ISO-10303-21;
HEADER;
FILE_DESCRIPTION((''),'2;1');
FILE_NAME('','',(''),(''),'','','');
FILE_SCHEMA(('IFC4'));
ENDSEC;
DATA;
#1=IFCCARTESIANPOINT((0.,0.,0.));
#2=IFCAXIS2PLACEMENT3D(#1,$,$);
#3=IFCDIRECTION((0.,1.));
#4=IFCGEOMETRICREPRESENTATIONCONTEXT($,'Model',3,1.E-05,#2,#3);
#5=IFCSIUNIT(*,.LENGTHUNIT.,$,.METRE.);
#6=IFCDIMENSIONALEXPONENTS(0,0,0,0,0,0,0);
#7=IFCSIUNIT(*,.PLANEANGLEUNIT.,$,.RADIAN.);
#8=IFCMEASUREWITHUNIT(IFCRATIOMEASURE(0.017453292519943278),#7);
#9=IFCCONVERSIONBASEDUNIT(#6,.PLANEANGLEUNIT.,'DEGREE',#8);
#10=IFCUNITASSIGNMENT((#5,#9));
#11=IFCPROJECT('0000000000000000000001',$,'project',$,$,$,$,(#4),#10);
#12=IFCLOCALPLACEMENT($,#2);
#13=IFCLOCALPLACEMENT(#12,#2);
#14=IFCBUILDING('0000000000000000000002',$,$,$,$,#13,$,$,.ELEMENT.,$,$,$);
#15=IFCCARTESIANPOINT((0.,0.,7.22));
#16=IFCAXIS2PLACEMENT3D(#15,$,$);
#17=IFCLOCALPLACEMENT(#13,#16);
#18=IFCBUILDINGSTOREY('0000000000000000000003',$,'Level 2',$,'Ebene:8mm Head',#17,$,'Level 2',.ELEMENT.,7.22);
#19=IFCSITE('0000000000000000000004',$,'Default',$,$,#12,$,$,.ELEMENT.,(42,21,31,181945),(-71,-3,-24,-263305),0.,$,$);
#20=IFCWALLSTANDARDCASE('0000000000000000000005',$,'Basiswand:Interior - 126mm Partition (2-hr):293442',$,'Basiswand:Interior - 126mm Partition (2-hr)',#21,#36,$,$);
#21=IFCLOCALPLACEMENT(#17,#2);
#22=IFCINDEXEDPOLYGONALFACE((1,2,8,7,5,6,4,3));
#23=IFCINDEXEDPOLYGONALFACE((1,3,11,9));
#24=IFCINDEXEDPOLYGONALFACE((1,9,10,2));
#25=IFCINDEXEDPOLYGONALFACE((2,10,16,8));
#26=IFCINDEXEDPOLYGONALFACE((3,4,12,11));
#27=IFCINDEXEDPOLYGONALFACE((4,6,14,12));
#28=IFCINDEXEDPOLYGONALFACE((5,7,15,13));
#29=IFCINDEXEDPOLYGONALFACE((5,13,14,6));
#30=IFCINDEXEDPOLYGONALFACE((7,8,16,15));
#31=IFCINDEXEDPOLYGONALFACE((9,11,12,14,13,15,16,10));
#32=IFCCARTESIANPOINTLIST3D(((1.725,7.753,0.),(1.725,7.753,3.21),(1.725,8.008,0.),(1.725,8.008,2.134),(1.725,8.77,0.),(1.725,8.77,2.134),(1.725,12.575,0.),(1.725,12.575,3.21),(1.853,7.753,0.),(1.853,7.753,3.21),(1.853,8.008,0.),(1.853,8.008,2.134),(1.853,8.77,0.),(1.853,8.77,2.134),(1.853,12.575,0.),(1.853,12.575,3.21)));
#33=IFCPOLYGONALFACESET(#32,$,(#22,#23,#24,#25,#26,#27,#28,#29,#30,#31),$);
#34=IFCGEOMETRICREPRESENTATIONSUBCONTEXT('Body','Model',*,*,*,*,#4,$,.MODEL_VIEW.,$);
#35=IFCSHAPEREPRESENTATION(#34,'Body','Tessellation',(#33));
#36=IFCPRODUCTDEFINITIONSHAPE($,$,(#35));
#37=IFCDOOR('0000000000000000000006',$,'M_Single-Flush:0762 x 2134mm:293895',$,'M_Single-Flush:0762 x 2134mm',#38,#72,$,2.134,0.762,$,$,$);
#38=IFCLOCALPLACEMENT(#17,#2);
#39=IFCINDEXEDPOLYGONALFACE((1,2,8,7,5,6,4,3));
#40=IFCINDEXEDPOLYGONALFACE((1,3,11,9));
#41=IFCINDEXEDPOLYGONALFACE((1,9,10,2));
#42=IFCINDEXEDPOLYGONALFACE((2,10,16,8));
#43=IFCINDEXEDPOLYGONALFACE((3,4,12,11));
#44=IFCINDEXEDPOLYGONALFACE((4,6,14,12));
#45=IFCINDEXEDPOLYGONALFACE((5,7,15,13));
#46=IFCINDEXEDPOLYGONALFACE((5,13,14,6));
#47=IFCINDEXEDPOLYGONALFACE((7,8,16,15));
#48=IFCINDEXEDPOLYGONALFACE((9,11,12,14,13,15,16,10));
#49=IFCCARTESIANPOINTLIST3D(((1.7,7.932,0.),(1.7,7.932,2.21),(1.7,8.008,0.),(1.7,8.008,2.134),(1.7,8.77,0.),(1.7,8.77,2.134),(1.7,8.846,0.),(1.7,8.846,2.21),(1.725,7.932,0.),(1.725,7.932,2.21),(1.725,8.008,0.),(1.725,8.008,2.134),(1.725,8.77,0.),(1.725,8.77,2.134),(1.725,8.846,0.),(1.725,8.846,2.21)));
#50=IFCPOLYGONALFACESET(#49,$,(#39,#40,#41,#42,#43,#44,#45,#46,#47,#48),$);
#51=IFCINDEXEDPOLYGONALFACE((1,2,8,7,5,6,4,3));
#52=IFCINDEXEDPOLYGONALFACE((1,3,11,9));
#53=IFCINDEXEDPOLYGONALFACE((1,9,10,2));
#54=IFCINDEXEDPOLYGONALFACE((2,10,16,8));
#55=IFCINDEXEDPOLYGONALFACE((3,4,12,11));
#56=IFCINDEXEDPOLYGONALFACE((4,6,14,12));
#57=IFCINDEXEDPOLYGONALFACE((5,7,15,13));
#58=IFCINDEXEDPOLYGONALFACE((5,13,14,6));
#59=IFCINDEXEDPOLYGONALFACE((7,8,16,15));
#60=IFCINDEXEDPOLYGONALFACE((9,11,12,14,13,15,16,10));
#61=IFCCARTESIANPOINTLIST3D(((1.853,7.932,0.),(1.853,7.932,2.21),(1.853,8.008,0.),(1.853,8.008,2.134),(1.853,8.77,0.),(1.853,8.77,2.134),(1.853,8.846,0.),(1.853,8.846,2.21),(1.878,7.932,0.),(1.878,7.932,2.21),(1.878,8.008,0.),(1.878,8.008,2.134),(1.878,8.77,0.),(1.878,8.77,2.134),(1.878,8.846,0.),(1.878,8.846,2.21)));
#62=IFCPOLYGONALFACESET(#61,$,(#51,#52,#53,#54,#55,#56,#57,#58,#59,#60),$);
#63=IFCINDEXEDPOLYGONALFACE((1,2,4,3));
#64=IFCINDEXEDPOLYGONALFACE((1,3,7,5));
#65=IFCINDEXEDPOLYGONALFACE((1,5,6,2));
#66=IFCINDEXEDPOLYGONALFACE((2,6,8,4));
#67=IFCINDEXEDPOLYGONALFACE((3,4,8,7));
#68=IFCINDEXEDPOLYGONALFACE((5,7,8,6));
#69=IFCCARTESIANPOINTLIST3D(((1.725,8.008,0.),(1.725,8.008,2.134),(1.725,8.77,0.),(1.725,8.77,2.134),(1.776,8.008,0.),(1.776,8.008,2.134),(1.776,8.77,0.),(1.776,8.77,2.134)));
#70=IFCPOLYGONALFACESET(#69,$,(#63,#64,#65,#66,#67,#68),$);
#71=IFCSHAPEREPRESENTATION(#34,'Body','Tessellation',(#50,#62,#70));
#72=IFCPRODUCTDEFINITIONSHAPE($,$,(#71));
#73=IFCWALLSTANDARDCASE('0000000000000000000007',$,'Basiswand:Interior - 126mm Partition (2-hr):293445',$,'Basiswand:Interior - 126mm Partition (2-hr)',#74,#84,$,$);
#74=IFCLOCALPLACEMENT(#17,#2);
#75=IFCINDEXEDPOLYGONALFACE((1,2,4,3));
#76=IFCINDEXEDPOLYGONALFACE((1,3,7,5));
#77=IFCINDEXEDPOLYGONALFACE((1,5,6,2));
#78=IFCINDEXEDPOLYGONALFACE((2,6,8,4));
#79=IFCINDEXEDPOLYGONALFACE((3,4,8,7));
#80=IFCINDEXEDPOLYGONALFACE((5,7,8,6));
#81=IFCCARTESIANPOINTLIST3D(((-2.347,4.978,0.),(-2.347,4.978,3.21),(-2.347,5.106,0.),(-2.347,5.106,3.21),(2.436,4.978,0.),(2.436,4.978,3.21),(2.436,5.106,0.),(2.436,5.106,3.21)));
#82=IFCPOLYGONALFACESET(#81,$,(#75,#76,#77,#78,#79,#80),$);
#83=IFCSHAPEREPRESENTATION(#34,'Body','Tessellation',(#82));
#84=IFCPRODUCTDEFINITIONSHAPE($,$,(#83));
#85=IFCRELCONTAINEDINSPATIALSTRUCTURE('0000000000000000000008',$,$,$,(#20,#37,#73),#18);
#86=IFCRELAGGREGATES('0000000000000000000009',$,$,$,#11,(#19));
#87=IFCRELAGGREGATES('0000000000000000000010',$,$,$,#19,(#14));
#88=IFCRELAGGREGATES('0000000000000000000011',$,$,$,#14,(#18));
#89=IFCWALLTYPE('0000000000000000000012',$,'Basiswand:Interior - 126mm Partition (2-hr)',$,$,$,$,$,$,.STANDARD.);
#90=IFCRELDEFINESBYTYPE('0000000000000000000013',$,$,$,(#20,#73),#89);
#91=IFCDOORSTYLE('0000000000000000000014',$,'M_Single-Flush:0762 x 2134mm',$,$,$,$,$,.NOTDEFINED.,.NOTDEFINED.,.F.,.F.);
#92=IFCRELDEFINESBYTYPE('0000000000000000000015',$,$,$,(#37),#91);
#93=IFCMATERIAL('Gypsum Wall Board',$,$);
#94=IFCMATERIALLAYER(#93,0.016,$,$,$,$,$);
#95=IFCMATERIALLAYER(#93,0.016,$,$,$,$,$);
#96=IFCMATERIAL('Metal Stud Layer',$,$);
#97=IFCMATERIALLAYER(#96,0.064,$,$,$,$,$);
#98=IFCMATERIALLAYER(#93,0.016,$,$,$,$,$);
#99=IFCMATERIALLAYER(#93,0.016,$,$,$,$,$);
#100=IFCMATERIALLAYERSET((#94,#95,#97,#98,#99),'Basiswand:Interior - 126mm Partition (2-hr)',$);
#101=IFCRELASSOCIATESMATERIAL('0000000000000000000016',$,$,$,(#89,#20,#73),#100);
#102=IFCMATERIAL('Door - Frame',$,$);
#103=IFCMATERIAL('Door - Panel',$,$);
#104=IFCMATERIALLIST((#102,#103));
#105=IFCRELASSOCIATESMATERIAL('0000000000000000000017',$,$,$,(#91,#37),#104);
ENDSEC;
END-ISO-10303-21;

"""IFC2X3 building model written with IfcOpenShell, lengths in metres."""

from ifc_helpers import new_model, entity, si_unit, converted_unit, direction, frame, frame_2d, origin, place, context, subcontext, project, spatial, polyline, rectangle, outline, extrude, clip, bounded_halfspace, source, transform, mapped, material, material_list, layer, layer_set, layer_usage, type_object, type_shapes, element, fill, save


model = new_model("IFC2X3")

# Units and contexts
model_context = context("Model", 3, precision=1e-05, world=origin(), true_north=direction((0.0, 1.0)))
body_context = subcontext(model_context, "Body", "Model", "MODEL_VIEW")
ifc_project = project(units=[si_unit("LENGTHUNIT", "METRE"), converted_unit("PLANEANGLEUNIT", "DEGREE", entity("IfcRatioMeasure", 0.017453292519943278), si_unit("PLANEANGLEUNIT", "RADIAN"), dimensions=[0, 0, 0, 0, 0, 0, 0])], contexts=[model_context])

# Site, building, storey
site_placement = place(None, origin())
site = spatial("IfcSite", under=ifc_project, at=site_placement, Name="Default", CompositionType="ELEMENT", RefLatitude=(42, 21, 31, 181945), RefLongitude=(-71, -3, -24, -263305), RefElevation=0.0)
building_placement = place(site_placement, origin())
building = spatial("IfcBuilding", under=site, at=building_placement, CompositionType="ELEMENT")
storey_placement = place(building_placement, frame((0.0, 0.0, 7.22)))
storey = spatial("IfcBuildingStorey", under=building, at=storey_placement, Name="Level 2", ObjectType="Ebene:8mm Head", LongName="Level 2", CompositionType="ELEMENT", Elevation=7.22)

# Wall, opening, door
ifc_material_1 = material(Name="Gypsum Wall Board")
ifc_layer_1 = layer(ifc_material_1, 0.016)
ifc_layer_2 = layer(ifc_material_1, 0.016)
ifc_material_2 = material(Name="Metal Stud Layer")
ifc_layer_3 = layer(ifc_material_2, 0.064)
ifc_layer_4 = layer(ifc_material_1, 0.016)
ifc_layer_5 = layer(ifc_material_1, 0.016)
ifc_layer_set = layer_set([ifc_layer_1, ifc_layer_2, ifc_layer_3, ifc_layer_4, ifc_layer_5], Name="Basiswand:Interior - 126mm Partition (2-hr)")
ifc_layer_usage_1 = layer_usage(ifc_layer_set, "AXIS2", "NEGATIVE", 0.064)
wall_type = type_object("IfcWallType", Name="Basiswand:Interior - 126mm Partition (2-hr)", PredefinedType="STANDARD", material=ifc_layer_set)
wall_1_placement = place(storey_placement, frame((1.789, 7.753, 0.0), z_axis=(0.0, 0.0, 1.0), x_axis=(0.0, 1.0, 0.0)))
wall_1 = element("IfcWallStandardCase", 1, at=wall_1_placement, inside=storey, type_object=wall_type, material=ifc_layer_usage_1, Name="Basiswand:Interior - 126mm Partition (2-hr):293442", ObjectType="Basiswand:Interior - 126mm Partition (2-hr)", context=body_context, shape_type="Clipping", body=[
    clip(extrude(rectangle(XDim=4.822, YDim=0.128, at=frame_2d((2.411, 0.0), x_axis=(1.0, 0.0))), origin(), (0.0, 0.0, 1.0), 3.21), bounded_halfspace(frame((0.0, -0.064, 3.21), z_axis=(0.0, 0.0, -1.0), x_axis=(1.0, 0.0, 0.0)), True, frame((0.0, -0.064, 3.21)), polyline([(0.0, 0.0), (4.822, 0.0), (4.822, 0.128), (0.0, 0.128), (0.0, 0.0)]))),
])
opening_1_placement = place(wall_1_placement, frame((0.255, -0.064, 0.0)))
opening_1 = element("IfcOpeningElement", 2, at=opening_1_placement, cuts=wall_1, ObjectType="Opening", context=body_context, shape_type="SweptSolid", body=[
    extrude(rectangle(XDim=0.762, YDim=2.134, at=frame_2d((1.067, 0.381), x_axis=(0.0, -1.0))), frame((0.0, 0.0, 0.0), z_axis=(0.0, 1.0, 0.0), x_axis=(0.0, 0.0, 1.0)), (0.0, 0.0, 1.0), 0.128),
])
ifc_material_3 = material(Name="Door - Frame")
ifc_material_4 = material(Name="Door - Panel")
ifc_material_list = material_list([ifc_material_3, ifc_material_4])
door_style_1 = type_object("IfcDoorStyle", Name="M_Single-Flush:0762 x 2134mm", ConstructionType="NOTDEFINED", OperationType="NOTDEFINED", ParameterTakesPrecedence=False, Sizeable=False, material=ifc_material_list)
shared_shape_1 = source(origin(), body_context, "Body", "SweptSolid", [
    extrude(outline(polyline([(-0.457, -1.124), (0.457, -1.124), (0.457, 1.086), (0.381, 1.086), (0.381, -1.048), (-0.381, -1.048), (-0.381, 1.086), (-0.457, 1.086), (-0.457, -1.124)])), frame((0.381, 0.153, 1.086), z_axis=(0.0, -1.0, 0.0), x_axis=(-1.0, 0.0, 0.0)), (0.0, 0.0, 1.0), 0.025),
    extrude(outline(polyline([(-1.124, -0.457), (1.086, -0.457), (1.086, -0.381), (-1.048, -0.381), (-1.048, 0.381), (1.086, 0.381), (1.086, 0.457), (-1.124, 0.457), (-1.124, -0.457)])), frame((0.381, 0.0, 1.086), z_axis=(0.0, -1.0, 0.0), x_axis=(0.0, 0.0, -1.0)), (0.0, 0.0, 1.0), 0.025),
    extrude(rectangle(XDim=0.762, YDim=0.051, at=frame_2d((0.0, 0.0), x_axis=(1.0, 0.0))), frame((0.381, 0.1025, 0.0)), (0.0, 0.0, 1.0), 2.134),
])
type_shapes(door_style_1, [shared_shape_1])
door_1_placement = place(opening_1_placement, origin())
door_1 = element("IfcDoor", 3, at=door_1_placement, inside=storey, type_object=door_style_1, material=ifc_material_list, Name="M_Single-Flush:0762 x 2134mm:293895", ObjectType="M_Single-Flush:0762 x 2134mm", OverallHeight=2.134, OverallWidth=0.762, context=body_context, shape_type="MappedRepresentation", body=[
    mapped(shared_shape_1, transform((0.0, 0.0, 0.0), scale=1.0)),
])
fill(opening_1, door_1)

# Wall
wall_2_placement = place(storey_placement, frame((-2.347, 5.042, 0.0)))
element("IfcWallStandardCase", 4, at=wall_2_placement, inside=storey, type_object=wall_type, material=ifc_layer_usage_1, Name="Basiswand:Interior - 126mm Partition (2-hr):293445", ObjectType="Basiswand:Interior - 126mm Partition (2-hr)", context=body_context, shape_type="Clipping", body=[
    clip(extrude(rectangle(XDim=4.783, YDim=0.128, at=frame_2d((2.3915, 0.0), x_axis=(-1.0, 0.0))), origin(), (0.0, 0.0, 1.0), 3.21), bounded_halfspace(frame((0.0, -0.064, 3.21), z_axis=(0.0, 0.0, -1.0), x_axis=(0.0, 1.0, 0.0)), True, frame((0.0, -0.064, 3.21)), polyline([(0.0, 0.0), (1.927, 0.0), (2.055, 0.0), (4.783, 0.0), (4.783, 0.128), (3.761, 0.128), (3.633, 0.128), (0.0, 0.128), (0.0, 0.0)]))),
])

save(model, "model.ifc")
